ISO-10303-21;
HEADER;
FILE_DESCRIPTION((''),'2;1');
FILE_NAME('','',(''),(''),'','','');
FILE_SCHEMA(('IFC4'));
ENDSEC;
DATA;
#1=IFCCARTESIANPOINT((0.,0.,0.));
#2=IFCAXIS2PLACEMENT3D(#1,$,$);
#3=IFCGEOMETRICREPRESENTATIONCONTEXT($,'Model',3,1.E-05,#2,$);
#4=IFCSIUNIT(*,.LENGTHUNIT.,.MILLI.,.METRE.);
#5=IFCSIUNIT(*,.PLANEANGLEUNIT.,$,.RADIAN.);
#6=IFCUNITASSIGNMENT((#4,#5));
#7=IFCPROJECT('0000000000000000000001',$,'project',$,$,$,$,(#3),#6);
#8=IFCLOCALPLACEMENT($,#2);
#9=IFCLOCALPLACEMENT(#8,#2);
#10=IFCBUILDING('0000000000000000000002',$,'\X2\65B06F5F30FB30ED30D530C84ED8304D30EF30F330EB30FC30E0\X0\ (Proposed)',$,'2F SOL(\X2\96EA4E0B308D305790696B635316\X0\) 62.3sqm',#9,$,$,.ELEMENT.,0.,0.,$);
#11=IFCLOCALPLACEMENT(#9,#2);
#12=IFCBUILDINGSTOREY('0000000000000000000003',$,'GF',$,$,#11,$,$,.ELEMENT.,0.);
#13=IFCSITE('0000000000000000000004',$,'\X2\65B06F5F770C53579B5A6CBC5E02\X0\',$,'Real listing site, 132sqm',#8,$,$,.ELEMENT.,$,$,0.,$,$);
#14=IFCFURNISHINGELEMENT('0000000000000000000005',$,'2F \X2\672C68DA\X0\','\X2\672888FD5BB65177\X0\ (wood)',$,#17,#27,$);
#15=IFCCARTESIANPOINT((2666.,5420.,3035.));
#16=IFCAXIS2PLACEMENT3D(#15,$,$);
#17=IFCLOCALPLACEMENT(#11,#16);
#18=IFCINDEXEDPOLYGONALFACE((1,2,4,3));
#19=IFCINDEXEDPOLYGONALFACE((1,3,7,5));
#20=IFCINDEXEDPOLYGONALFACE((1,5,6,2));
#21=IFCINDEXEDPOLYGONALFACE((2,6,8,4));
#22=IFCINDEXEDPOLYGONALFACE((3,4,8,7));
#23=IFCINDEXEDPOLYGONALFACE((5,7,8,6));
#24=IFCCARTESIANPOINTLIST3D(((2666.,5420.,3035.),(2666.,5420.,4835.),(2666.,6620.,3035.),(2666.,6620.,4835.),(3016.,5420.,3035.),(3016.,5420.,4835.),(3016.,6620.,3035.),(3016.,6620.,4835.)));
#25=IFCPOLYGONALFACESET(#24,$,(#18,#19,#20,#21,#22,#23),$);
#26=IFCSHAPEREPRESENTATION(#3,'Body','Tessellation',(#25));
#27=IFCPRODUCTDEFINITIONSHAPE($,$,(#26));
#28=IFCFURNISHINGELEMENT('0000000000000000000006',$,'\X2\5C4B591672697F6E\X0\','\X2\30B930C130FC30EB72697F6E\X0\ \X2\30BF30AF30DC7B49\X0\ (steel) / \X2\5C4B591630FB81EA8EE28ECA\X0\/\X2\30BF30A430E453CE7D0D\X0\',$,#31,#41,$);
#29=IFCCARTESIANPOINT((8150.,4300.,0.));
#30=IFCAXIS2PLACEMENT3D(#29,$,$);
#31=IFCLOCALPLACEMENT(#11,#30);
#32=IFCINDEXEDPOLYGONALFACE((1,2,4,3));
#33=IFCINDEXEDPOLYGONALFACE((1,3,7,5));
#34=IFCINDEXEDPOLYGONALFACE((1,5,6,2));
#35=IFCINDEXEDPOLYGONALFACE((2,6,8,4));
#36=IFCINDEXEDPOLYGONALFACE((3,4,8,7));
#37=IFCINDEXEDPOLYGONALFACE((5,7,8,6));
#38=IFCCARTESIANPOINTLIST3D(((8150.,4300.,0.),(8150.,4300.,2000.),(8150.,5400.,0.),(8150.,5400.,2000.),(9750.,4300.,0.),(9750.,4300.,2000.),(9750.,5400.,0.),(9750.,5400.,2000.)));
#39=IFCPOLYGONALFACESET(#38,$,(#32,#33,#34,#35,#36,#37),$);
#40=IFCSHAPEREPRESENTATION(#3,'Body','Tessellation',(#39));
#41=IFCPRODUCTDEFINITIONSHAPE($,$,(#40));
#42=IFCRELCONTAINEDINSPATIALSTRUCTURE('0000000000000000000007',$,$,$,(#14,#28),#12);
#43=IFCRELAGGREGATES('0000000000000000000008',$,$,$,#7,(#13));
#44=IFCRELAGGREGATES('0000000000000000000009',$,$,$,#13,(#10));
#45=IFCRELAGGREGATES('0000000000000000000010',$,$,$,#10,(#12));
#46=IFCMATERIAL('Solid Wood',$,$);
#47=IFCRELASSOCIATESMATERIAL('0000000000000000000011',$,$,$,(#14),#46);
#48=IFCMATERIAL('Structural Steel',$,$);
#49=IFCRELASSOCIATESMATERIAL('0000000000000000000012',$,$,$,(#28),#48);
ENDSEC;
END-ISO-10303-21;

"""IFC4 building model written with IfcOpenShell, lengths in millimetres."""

from ifc_helpers import new_model, si_unit, frame, frame_2d, origin, place, context, project, spatial, rectangle, extrude, material, element, save


model = new_model("IFC4")

# Units and contexts
model_context = context("Model", 3, precision=1e-05, world=origin())
ifc_project = project(units=[si_unit("LENGTHUNIT", "METRE", prefix="MILLI"), si_unit("PLANEANGLEUNIT", "RADIAN")], contexts=[model_context])

# Site, building, storey
site_placement = place(None, origin())
site = spatial("IfcSite", under=ifc_project, at=site_placement, Name="新潟県南魚沼市", ObjectType="Real listing site, 132sqm", CompositionType="ELEMENT", RefElevation=0.0)
building_placement = place(site_placement, origin())
building = spatial("IfcBuilding", under=site, at=building_placement, Name="新潟・ロフト付きワンルーム (Proposed)", ObjectType="2F SOL(雪下ろし適正化) 62.3sqm", CompositionType="ELEMENT", ElevationOfRefHeight=0.0, ElevationOfTerrain=0.0)
storey_placement = place(building_placement, origin())
storey = spatial("IfcBuildingStorey", under=building, at=storey_placement, Name="GF", CompositionType="ELEMENT", Elevation=0.0)

# Shared definitions
ifc_material_1 = material(Name="Solid Wood")

# Shared definitions
ifc_material_2 = material(Name="Structural Steel")

# Furnishing elements
furnishing_1_placement = place(storey_placement, frame((2666.0, 5420.0, 3035.0)))
element("IfcFurnishingElement", 1, at=furnishing_1_placement, inside=storey, material=ifc_material_1, Name="2F 本棚", Description="木製家具 (wood)", context=model_context, shape_type="SweptSolid", body=[
    extrude(rectangle(XDim=350.0, YDim=1200.0, at=frame_2d((175.0, 600.0))), frame((2666.0, 5420.0, 3035.0)), (0.0, 0.0, 1.0), 1800.0),
])
furnishing_2_placement = place(storey_placement, frame((8150.0, 4300.0, 0.0)))
element("IfcFurnishingElement", 2, at=furnishing_2_placement, inside=storey, material=ifc_material_2, Name="屋外物置", Description="スチール物置 タクボ等 (steel) / 屋外・自転車/タイヤ収納", context=model_context, shape_type="SweptSolid", body=[
    extrude(rectangle(XDim=1600.0, YDim=1100.0, at=frame_2d((800.0, 550.0))), frame((8150.0, 4300.0, 0.0)), (0.0, 0.0, 1.0), 2000.0),
])

save(model, "model.ifc")
